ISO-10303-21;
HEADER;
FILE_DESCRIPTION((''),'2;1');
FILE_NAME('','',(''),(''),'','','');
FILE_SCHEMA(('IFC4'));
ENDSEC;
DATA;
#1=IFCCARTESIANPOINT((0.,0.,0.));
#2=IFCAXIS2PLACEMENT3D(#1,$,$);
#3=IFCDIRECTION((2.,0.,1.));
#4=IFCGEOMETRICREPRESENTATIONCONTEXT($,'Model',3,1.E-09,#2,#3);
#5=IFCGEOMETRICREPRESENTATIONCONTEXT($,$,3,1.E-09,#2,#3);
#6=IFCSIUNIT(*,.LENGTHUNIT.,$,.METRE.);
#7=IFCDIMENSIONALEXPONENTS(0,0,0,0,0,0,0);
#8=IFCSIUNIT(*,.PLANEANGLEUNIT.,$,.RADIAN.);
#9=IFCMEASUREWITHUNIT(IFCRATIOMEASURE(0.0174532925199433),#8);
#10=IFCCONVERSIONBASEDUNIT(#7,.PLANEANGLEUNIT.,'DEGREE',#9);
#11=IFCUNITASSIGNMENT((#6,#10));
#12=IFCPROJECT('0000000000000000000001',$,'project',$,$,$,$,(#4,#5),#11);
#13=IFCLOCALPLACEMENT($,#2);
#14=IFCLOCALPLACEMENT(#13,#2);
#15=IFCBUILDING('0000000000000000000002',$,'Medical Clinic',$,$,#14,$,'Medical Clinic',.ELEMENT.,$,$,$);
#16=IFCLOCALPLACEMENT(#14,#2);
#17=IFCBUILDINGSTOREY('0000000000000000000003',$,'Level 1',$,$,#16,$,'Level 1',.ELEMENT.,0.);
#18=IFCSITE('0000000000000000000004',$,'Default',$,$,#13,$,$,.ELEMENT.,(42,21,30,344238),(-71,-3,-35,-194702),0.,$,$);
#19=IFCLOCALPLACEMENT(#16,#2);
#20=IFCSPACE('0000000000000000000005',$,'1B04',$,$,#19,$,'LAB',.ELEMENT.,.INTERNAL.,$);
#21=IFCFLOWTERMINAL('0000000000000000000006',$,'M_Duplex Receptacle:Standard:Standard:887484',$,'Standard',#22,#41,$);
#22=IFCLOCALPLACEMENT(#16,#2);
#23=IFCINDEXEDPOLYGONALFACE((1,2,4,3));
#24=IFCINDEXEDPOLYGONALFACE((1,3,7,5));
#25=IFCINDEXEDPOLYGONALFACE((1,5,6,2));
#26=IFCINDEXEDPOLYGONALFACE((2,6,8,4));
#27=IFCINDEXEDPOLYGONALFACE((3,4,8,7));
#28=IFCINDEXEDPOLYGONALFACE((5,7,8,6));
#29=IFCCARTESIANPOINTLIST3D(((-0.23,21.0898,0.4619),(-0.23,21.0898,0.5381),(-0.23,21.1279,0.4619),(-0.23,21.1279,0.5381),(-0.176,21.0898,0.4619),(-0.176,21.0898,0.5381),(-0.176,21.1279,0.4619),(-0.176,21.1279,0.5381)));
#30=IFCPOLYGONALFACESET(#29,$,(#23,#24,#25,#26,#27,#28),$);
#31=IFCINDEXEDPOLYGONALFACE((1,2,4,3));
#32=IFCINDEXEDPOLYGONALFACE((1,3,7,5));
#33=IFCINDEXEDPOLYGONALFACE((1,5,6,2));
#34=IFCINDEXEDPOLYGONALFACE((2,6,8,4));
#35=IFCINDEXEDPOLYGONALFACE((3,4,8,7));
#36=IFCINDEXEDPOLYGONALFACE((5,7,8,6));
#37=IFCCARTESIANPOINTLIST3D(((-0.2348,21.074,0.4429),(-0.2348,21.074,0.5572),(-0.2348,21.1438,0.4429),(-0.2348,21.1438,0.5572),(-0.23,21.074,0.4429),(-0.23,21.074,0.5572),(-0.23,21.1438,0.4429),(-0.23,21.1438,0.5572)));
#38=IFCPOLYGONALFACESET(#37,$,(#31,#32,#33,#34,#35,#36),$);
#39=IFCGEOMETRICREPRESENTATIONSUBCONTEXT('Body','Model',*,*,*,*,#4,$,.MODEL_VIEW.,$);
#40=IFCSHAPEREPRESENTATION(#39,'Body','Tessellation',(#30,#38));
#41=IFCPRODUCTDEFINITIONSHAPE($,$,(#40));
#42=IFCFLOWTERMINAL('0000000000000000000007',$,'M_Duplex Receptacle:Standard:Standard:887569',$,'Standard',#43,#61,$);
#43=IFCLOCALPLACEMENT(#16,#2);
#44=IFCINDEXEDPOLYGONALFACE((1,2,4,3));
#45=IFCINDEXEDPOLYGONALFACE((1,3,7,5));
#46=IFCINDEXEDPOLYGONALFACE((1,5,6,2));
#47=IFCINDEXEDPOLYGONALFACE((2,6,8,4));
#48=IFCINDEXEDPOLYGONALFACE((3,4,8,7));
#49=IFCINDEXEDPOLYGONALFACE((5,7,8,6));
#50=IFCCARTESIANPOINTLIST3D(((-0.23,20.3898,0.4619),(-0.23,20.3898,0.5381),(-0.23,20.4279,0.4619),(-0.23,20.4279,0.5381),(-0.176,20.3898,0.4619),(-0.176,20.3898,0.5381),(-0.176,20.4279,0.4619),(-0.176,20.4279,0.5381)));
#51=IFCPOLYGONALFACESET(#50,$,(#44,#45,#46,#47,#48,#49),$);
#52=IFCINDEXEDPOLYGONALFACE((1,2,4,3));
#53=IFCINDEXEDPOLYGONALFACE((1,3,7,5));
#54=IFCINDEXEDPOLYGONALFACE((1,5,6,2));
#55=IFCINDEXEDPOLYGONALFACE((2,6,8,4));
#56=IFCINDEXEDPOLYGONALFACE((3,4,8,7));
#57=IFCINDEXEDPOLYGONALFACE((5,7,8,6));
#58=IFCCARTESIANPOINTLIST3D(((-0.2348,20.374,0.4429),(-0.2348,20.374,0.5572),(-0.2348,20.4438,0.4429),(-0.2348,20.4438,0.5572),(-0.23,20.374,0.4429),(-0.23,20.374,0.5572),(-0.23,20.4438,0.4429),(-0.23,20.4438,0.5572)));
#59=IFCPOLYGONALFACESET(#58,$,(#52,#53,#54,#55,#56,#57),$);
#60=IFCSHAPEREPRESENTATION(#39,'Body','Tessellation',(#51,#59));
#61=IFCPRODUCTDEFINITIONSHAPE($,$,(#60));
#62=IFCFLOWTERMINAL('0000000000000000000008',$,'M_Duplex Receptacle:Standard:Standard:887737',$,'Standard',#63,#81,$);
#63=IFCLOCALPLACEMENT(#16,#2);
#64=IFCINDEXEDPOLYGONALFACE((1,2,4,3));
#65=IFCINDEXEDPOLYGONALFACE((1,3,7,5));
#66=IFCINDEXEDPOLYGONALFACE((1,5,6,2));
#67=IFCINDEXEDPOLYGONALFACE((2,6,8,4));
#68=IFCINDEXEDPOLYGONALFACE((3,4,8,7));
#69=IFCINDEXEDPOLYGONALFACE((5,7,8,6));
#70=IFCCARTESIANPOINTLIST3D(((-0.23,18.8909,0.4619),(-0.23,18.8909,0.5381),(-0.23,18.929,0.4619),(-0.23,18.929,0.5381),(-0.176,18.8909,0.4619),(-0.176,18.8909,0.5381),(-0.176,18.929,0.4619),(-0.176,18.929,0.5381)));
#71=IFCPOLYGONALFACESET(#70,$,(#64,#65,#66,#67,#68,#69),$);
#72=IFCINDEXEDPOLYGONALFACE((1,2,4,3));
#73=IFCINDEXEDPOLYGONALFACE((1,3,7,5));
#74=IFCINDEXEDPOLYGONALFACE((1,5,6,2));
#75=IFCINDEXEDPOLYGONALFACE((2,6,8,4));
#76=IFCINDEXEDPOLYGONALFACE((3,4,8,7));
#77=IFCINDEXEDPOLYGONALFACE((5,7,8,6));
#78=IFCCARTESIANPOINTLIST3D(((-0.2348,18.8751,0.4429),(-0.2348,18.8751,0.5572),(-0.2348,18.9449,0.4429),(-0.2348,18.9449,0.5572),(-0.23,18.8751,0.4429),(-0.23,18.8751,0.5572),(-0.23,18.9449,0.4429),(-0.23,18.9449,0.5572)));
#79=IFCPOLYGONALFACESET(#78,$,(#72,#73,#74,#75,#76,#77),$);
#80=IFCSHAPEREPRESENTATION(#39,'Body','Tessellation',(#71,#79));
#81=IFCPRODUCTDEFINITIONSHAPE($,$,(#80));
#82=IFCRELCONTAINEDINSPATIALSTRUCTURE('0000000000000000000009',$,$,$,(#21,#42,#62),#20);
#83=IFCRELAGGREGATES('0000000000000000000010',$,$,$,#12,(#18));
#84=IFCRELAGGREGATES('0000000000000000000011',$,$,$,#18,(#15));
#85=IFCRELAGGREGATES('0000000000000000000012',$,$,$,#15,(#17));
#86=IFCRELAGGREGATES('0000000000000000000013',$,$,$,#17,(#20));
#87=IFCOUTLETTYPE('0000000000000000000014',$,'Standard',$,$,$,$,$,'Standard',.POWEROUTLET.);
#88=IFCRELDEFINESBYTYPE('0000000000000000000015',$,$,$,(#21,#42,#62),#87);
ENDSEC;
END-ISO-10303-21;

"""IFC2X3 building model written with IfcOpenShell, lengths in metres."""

from ifc_helpers import new_model, entity, si_unit, converted_unit, direction, frame, frame_2d, origin, origin_2d_with_axis, place, context, subcontext, project, spatial, rectangle, extrude, source, transform, mapped, type_object, type_shapes, element, save


model = new_model("IFC2X3")

# Units and contexts
model_context = context("Model", 3, precision=1e-09, world=origin(), true_north=direction((2.0, 0.0, 1.0)))
context_of_model = context(None, 3, precision=1e-09, world=origin(), true_north=direction((2.0, 0.0, 1.0)))
body_context = subcontext(model_context, "Body", "Model", "MODEL_VIEW")
ifc_project = project(units=[si_unit("LENGTHUNIT", "METRE"), converted_unit("PLANEANGLEUNIT", "DEGREE", entity("IfcRatioMeasure", 0.0174532925199433), si_unit("PLANEANGLEUNIT", "RADIAN"), dimensions=[0, 0, 0, 0, 0, 0, 0])], contexts=[model_context, context_of_model])

# Site, building, storey
site_placement = place(None, origin())
site = spatial("IfcSite", under=ifc_project, at=site_placement, Name="Default", CompositionType="ELEMENT", RefLatitude=(42, 21, 30, 344238), RefLongitude=(-71, -3, -35, -194702), RefElevation=0.0)
building_placement = place(site_placement, origin())
building = spatial("IfcBuilding", under=site, at=building_placement, Name="Medical Clinic", LongName="Medical Clinic", CompositionType="ELEMENT")
storey_placement = place(building_placement, origin())
storey = spatial("IfcBuildingStorey", under=building, at=storey_placement, Name="Level 1", LongName="Level 1", CompositionType="ELEMENT", Elevation=0.0)

# Shared definitions
space_1_placement = place(storey_placement, origin())
space_1 = spatial("IfcSpace", under=storey, at=space_1_placement, Name="1B04", LongName="LAB", CompositionType="ELEMENT", InteriorOrExteriorSpace="INTERNAL")

# Shared definitions
outlet_type = type_object("IfcOutletType", Name="Standard", ElementType="Standard", PredefinedType="POWEROUTLET")
shared_shape_1 = source(origin(), body_context, "Body", "SweptSolid", [
    extrude(rectangle(XDim=0.0381, YDim=0.0762, at=origin_2d_with_axis()), frame((0.0, 0.0, -0.054), z_axis=(0.0, 0.0, 1.0), x_axis=(-1.0, 0.0, 0.0)), (0.0, 0.0, 1.0), 0.054),
    extrude(rectangle(XDim=0.0698, YDim=0.1143, at=frame_2d((0.0, 0.0), x_axis=(1.0, 0.0))), frame((0.0, 0.0, 0.0), z_axis=(0.0, 0.0, 1.0), x_axis=(-1.0, 0.0, 0.0)), (0.0, 0.0, 1.0), 0.0048),
])
type_shapes(outlet_type, [shared_shape_1])

# Flow terminals
for number, where, z_axis, x_axis, name in (
    (1, (-0.23, 21.1089, 0.5), (-1.0, 0.0, 0.0), (0.0, -1.0, 0.0), "M_Duplex Receptacle:Standard:Standard:887484"),
    (2, (-0.23, 20.4089, 0.5), (-1.0, 0.0, 0.0), (0.0, -1.0, 0.0), "M_Duplex Receptacle:Standard:Standard:887569"),
    (3, (-0.23, 18.91, 0.5), (-1.0, 0.0, 0.0), (0.0, -1.0, 0.0), "M_Duplex Receptacle:Standard:Standard:887737"),
):
    element("IfcFlowTerminal", number, at=place(space_1_placement, frame(where, z_axis=z_axis, x_axis=x_axis)), inside=space_1, type_object=outlet_type, Name=name, ObjectType="Standard", context=body_context, shape_type="MappedRepresentation", body=[
        mapped(shared_shape_1, transform((0.0, 0.0, 0.0), scale=1.0)),
    ])

save(model, "model.ifc")
